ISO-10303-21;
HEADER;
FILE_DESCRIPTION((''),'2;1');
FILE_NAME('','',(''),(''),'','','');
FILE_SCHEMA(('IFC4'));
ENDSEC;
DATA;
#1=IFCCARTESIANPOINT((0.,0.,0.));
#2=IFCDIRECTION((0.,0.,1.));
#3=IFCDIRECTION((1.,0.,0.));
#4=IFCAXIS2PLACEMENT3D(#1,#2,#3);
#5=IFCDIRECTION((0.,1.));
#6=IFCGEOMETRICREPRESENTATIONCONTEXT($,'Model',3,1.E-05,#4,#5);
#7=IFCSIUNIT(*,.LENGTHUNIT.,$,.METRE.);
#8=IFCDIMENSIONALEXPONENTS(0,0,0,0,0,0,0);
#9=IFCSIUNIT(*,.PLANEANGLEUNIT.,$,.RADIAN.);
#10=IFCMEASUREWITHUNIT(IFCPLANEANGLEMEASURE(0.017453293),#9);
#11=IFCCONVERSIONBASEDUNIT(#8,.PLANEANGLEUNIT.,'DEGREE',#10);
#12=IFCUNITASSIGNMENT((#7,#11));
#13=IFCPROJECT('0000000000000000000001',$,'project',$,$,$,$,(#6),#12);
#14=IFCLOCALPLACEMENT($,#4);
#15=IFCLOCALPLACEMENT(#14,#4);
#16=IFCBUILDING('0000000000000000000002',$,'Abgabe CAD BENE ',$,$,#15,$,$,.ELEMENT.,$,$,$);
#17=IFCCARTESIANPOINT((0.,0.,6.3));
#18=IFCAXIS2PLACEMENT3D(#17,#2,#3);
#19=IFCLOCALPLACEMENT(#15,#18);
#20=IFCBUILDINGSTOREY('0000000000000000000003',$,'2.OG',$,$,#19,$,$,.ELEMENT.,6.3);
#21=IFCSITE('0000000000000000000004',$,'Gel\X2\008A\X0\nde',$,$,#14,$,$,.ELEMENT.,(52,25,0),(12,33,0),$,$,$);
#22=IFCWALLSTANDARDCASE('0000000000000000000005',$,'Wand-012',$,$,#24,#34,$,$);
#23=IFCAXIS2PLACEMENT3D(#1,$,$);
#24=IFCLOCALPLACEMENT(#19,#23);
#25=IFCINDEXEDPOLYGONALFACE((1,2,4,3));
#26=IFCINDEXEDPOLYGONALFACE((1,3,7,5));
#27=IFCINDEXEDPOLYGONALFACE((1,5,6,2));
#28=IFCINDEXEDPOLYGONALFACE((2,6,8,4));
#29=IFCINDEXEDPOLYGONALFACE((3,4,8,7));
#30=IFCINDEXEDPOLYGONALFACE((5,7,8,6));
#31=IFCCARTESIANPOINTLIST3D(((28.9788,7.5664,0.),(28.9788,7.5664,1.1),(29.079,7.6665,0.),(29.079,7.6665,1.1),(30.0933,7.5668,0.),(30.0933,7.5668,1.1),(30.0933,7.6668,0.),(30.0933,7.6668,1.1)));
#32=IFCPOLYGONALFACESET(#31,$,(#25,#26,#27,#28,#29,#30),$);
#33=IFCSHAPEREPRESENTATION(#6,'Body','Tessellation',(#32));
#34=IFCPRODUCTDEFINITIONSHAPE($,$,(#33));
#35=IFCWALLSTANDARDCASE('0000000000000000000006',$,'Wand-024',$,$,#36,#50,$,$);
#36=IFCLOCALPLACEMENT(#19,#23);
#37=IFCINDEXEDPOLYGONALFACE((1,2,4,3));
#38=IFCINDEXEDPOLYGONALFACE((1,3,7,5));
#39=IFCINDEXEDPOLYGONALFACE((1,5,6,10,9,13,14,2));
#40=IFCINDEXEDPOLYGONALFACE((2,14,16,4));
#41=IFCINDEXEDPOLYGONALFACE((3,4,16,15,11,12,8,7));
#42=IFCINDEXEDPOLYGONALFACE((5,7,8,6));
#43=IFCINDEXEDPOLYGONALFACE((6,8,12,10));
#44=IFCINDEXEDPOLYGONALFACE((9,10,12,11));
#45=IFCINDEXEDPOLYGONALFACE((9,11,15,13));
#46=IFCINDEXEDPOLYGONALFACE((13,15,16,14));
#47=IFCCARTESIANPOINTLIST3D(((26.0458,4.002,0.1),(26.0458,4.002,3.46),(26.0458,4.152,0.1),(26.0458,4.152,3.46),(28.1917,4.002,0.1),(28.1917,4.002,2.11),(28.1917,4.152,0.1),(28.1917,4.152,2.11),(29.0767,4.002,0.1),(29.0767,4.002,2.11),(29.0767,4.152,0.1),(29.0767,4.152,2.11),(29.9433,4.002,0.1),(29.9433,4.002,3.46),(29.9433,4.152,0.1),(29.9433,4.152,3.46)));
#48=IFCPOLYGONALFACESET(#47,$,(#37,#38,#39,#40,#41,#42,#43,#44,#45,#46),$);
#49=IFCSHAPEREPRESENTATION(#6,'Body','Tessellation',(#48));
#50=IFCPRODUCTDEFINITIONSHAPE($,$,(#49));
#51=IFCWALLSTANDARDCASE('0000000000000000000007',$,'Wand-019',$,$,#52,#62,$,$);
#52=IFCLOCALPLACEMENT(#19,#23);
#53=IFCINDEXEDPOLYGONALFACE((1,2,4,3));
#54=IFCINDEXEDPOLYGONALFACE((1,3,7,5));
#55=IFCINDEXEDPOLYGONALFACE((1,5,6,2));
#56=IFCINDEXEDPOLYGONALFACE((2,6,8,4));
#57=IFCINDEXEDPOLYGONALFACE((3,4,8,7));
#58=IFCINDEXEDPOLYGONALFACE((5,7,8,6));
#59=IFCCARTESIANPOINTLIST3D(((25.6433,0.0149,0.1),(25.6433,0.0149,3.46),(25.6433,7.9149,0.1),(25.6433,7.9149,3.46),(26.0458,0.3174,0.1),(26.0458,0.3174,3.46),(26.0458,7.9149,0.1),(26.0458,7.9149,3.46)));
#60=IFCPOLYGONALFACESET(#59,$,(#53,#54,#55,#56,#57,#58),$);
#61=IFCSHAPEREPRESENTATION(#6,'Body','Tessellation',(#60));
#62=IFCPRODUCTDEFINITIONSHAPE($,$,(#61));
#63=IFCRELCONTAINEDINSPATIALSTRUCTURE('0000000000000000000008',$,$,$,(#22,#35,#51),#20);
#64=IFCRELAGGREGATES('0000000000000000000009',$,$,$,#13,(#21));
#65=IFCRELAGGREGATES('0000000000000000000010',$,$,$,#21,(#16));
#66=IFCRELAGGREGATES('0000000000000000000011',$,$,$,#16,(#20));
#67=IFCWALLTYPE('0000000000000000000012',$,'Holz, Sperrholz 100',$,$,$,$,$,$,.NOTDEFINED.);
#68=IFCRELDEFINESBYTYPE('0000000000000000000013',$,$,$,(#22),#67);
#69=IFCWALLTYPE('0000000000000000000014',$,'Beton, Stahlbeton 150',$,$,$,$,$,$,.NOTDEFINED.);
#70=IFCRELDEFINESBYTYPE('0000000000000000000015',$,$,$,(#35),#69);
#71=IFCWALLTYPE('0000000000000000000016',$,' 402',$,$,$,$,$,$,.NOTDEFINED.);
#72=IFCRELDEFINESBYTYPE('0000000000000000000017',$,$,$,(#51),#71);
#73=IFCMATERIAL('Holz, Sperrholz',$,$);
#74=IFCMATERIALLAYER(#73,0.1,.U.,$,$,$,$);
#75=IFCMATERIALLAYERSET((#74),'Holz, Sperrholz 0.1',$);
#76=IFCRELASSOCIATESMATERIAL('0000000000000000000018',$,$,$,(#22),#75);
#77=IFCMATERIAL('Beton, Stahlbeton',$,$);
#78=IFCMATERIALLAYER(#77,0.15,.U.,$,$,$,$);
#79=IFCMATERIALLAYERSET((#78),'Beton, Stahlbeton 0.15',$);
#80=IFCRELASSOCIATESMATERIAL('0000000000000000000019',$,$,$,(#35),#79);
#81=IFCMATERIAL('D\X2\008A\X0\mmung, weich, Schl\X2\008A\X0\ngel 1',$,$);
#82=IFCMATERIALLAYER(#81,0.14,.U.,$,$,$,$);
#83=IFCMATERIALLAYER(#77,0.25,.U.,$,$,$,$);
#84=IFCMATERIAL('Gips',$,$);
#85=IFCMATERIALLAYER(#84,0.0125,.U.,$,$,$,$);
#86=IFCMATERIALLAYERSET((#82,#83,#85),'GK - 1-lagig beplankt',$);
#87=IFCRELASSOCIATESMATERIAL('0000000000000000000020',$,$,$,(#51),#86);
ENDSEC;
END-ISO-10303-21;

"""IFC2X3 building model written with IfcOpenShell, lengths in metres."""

from ifc_helpers import new_model, entity, si_unit, converted_unit, direction, frame, origin_with_axes, origin_2d_with_axis, place, context, project, spatial, polyline, rectangle, outline, extrude, material, layer, layer_set, layer_usage, type_object, element, save


model = new_model("IFC2X3")

# Units and contexts
model_context = context("Model", 3, precision=1e-05, world=origin_with_axes(), true_north=direction((0.0, 1.0)))
ifc_project = project(units=[si_unit("LENGTHUNIT", "METRE"), converted_unit("PLANEANGLEUNIT", "DEGREE", entity("IfcPlaneAngleMeasure", 0.017453293), si_unit("PLANEANGLEUNIT", "RADIAN"), dimensions=[0, 0, 0, 0, 0, 0, 0])], contexts=[model_context])

# Site, building, storey
site_placement = place(None, origin_with_axes())
site = spatial("IfcSite", under=ifc_project, at=site_placement, Name="Gel\u008ande", CompositionType="ELEMENT", RefLatitude=(52, 25, 0), RefLongitude=(12, 33, 0))
building_placement = place(site_placement, origin_with_axes())
building = spatial("IfcBuilding", under=site, at=building_placement, Name="Abgabe CAD BENE ", CompositionType="ELEMENT")
storey_placement = place(building_placement, frame((0.0, 0.0, 6.3), z_axis=(0.0, 0.0, 1.0), x_axis=(1.0, 0.0, 0.0)))
storey = spatial("IfcBuildingStorey", under=building, at=storey_placement, Name="2.OG", CompositionType="ELEMENT", Elevation=6.3)

# Wall
ifc_material_1 = material(Name="Holz, Sperrholz")
ifc_layer_1 = layer(ifc_material_1, 0.1, ventilated="UNKNOWN")
ifc_layer_set_1 = layer_set([ifc_layer_1], Name="Holz, Sperrholz 0.1")
wall_type_1 = type_object("IfcWallType", Name="Holz, Sperrholz 100", PredefinedType="NOTDEFINED")
ifc_layer_usage_1 = layer_usage(ifc_layer_set_1, "AXIS2", "NEGATIVE", 0.0)
wall_1_placement = place(storey_placement, frame((28.9789, 7.6664, 0.0), z_axis=(0.0, 0.0, 1.0), x_axis=(1.0, 0.000367, 0.0)))
element("IfcWallStandardCase", 1, at=wall_1_placement, inside=storey, type_object=wall_type_1, material=ifc_layer_usage_1, Name="Wand-012", context=model_context, shape_type="SweptSolid", body=[
    extrude(outline(polyline([(-0.0001, -0.1), (1.1144, -0.1), (1.1144, 0.0), (0.1001, 0.0), (-0.0001, -0.1)])), origin_with_axes(), (0.0, 0.0, 1.0), 1.1),
])
ifc_material_2 = material(Name="Beton, Stahlbeton")
ifc_layer_2 = layer(ifc_material_2, 0.15, ventilated="UNKNOWN")
ifc_layer_set_2 = layer_set([ifc_layer_2], Name="Beton, Stahlbeton 0.15")
wall_type_2 = type_object("IfcWallType", Name="Beton, Stahlbeton 150", PredefinedType="NOTDEFINED")

# Wall, opening
ifc_layer_usage_2 = layer_usage(ifc_layer_set_2, "AXIS2", "NEGATIVE", 0.0)
wall_2_placement = place(storey_placement, frame((29.9433, 4.002, 0.1), z_axis=(0.0, 0.0, 1.0), x_axis=(-1.0, 0.0, 0.0)))
wall_2 = element("IfcWallStandardCase", 2, at=wall_2_placement, inside=storey, type_object=wall_type_2, material=ifc_layer_usage_2, Name="Wand-024", context=model_context, shape_type="SweptSolid", body=[
    extrude(outline(polyline([(0.0, -0.15), (3.8975, -0.15), (3.8975, 0.0), (0.0, 0.0), (0.0, -0.15)])), origin_with_axes(), (0.0, 0.0, 1.0), 3.36),
])
opening_1_placement = place(wall_2_placement, frame((1.3091, 0.0, 0.0), z_axis=(0.0, 0.0, 1.0), x_axis=(1.0, 0.0, 0.0)))
element("IfcOpeningElement", 3, at=opening_1_placement, cuts=wall_2, context=model_context, shape_type="SweptSolid", body=[
    extrude(rectangle(XDim=0.885, YDim=2.01, at=origin_2d_with_axis()), frame((0.0, -0.151, 1.005), z_axis=(0.0, 1.0, 0.0), x_axis=(1.0, 0.0, 0.0)), (0.0, 0.0, 1.0), 0.452),
])

# Wall
ifc_material_3 = material(Name="D\u008ammung, weich, Schl\u008angel 1")
ifc_layer_3 = layer(ifc_material_3, 0.14, ventilated="UNKNOWN")
ifc_layer_4 = layer(ifc_material_2, 0.25, ventilated="UNKNOWN")
ifc_material_4 = material(Name="Gips")
ifc_layer_5 = layer(ifc_material_4, 0.0125, ventilated="UNKNOWN")
ifc_layer_set_3 = layer_set([ifc_layer_3, ifc_layer_4, ifc_layer_5], Name="GK - 1-lagig beplankt")
ifc_layer_usage_3 = layer_usage(ifc_layer_set_3, "AXIS2", "NEGATIVE", 0.0)
wall_type_3 = type_object("IfcWallType", Name=" 402", PredefinedType="NOTDEFINED")
wall_3_placement = place(storey_placement, frame((25.6433, 0.0149, 0.1), z_axis=(0.0, 0.0, 1.0), x_axis=(0.0, 1.0, 0.0)))
element("IfcWallStandardCase", 4, at=wall_3_placement, inside=storey, type_object=wall_type_3, material=ifc_layer_usage_3, Name="Wand-019", context=model_context, shape_type="SweptSolid", body=[
    extrude(outline(polyline([(0.3025, -0.4025), (7.9, -0.4025), (7.9, 0.0), (0.0, 0.0), (0.3025, -0.4025)])), origin_with_axes(), (0.0, 0.0, 1.0), 3.36),
])

save(model, "model.ifc")
